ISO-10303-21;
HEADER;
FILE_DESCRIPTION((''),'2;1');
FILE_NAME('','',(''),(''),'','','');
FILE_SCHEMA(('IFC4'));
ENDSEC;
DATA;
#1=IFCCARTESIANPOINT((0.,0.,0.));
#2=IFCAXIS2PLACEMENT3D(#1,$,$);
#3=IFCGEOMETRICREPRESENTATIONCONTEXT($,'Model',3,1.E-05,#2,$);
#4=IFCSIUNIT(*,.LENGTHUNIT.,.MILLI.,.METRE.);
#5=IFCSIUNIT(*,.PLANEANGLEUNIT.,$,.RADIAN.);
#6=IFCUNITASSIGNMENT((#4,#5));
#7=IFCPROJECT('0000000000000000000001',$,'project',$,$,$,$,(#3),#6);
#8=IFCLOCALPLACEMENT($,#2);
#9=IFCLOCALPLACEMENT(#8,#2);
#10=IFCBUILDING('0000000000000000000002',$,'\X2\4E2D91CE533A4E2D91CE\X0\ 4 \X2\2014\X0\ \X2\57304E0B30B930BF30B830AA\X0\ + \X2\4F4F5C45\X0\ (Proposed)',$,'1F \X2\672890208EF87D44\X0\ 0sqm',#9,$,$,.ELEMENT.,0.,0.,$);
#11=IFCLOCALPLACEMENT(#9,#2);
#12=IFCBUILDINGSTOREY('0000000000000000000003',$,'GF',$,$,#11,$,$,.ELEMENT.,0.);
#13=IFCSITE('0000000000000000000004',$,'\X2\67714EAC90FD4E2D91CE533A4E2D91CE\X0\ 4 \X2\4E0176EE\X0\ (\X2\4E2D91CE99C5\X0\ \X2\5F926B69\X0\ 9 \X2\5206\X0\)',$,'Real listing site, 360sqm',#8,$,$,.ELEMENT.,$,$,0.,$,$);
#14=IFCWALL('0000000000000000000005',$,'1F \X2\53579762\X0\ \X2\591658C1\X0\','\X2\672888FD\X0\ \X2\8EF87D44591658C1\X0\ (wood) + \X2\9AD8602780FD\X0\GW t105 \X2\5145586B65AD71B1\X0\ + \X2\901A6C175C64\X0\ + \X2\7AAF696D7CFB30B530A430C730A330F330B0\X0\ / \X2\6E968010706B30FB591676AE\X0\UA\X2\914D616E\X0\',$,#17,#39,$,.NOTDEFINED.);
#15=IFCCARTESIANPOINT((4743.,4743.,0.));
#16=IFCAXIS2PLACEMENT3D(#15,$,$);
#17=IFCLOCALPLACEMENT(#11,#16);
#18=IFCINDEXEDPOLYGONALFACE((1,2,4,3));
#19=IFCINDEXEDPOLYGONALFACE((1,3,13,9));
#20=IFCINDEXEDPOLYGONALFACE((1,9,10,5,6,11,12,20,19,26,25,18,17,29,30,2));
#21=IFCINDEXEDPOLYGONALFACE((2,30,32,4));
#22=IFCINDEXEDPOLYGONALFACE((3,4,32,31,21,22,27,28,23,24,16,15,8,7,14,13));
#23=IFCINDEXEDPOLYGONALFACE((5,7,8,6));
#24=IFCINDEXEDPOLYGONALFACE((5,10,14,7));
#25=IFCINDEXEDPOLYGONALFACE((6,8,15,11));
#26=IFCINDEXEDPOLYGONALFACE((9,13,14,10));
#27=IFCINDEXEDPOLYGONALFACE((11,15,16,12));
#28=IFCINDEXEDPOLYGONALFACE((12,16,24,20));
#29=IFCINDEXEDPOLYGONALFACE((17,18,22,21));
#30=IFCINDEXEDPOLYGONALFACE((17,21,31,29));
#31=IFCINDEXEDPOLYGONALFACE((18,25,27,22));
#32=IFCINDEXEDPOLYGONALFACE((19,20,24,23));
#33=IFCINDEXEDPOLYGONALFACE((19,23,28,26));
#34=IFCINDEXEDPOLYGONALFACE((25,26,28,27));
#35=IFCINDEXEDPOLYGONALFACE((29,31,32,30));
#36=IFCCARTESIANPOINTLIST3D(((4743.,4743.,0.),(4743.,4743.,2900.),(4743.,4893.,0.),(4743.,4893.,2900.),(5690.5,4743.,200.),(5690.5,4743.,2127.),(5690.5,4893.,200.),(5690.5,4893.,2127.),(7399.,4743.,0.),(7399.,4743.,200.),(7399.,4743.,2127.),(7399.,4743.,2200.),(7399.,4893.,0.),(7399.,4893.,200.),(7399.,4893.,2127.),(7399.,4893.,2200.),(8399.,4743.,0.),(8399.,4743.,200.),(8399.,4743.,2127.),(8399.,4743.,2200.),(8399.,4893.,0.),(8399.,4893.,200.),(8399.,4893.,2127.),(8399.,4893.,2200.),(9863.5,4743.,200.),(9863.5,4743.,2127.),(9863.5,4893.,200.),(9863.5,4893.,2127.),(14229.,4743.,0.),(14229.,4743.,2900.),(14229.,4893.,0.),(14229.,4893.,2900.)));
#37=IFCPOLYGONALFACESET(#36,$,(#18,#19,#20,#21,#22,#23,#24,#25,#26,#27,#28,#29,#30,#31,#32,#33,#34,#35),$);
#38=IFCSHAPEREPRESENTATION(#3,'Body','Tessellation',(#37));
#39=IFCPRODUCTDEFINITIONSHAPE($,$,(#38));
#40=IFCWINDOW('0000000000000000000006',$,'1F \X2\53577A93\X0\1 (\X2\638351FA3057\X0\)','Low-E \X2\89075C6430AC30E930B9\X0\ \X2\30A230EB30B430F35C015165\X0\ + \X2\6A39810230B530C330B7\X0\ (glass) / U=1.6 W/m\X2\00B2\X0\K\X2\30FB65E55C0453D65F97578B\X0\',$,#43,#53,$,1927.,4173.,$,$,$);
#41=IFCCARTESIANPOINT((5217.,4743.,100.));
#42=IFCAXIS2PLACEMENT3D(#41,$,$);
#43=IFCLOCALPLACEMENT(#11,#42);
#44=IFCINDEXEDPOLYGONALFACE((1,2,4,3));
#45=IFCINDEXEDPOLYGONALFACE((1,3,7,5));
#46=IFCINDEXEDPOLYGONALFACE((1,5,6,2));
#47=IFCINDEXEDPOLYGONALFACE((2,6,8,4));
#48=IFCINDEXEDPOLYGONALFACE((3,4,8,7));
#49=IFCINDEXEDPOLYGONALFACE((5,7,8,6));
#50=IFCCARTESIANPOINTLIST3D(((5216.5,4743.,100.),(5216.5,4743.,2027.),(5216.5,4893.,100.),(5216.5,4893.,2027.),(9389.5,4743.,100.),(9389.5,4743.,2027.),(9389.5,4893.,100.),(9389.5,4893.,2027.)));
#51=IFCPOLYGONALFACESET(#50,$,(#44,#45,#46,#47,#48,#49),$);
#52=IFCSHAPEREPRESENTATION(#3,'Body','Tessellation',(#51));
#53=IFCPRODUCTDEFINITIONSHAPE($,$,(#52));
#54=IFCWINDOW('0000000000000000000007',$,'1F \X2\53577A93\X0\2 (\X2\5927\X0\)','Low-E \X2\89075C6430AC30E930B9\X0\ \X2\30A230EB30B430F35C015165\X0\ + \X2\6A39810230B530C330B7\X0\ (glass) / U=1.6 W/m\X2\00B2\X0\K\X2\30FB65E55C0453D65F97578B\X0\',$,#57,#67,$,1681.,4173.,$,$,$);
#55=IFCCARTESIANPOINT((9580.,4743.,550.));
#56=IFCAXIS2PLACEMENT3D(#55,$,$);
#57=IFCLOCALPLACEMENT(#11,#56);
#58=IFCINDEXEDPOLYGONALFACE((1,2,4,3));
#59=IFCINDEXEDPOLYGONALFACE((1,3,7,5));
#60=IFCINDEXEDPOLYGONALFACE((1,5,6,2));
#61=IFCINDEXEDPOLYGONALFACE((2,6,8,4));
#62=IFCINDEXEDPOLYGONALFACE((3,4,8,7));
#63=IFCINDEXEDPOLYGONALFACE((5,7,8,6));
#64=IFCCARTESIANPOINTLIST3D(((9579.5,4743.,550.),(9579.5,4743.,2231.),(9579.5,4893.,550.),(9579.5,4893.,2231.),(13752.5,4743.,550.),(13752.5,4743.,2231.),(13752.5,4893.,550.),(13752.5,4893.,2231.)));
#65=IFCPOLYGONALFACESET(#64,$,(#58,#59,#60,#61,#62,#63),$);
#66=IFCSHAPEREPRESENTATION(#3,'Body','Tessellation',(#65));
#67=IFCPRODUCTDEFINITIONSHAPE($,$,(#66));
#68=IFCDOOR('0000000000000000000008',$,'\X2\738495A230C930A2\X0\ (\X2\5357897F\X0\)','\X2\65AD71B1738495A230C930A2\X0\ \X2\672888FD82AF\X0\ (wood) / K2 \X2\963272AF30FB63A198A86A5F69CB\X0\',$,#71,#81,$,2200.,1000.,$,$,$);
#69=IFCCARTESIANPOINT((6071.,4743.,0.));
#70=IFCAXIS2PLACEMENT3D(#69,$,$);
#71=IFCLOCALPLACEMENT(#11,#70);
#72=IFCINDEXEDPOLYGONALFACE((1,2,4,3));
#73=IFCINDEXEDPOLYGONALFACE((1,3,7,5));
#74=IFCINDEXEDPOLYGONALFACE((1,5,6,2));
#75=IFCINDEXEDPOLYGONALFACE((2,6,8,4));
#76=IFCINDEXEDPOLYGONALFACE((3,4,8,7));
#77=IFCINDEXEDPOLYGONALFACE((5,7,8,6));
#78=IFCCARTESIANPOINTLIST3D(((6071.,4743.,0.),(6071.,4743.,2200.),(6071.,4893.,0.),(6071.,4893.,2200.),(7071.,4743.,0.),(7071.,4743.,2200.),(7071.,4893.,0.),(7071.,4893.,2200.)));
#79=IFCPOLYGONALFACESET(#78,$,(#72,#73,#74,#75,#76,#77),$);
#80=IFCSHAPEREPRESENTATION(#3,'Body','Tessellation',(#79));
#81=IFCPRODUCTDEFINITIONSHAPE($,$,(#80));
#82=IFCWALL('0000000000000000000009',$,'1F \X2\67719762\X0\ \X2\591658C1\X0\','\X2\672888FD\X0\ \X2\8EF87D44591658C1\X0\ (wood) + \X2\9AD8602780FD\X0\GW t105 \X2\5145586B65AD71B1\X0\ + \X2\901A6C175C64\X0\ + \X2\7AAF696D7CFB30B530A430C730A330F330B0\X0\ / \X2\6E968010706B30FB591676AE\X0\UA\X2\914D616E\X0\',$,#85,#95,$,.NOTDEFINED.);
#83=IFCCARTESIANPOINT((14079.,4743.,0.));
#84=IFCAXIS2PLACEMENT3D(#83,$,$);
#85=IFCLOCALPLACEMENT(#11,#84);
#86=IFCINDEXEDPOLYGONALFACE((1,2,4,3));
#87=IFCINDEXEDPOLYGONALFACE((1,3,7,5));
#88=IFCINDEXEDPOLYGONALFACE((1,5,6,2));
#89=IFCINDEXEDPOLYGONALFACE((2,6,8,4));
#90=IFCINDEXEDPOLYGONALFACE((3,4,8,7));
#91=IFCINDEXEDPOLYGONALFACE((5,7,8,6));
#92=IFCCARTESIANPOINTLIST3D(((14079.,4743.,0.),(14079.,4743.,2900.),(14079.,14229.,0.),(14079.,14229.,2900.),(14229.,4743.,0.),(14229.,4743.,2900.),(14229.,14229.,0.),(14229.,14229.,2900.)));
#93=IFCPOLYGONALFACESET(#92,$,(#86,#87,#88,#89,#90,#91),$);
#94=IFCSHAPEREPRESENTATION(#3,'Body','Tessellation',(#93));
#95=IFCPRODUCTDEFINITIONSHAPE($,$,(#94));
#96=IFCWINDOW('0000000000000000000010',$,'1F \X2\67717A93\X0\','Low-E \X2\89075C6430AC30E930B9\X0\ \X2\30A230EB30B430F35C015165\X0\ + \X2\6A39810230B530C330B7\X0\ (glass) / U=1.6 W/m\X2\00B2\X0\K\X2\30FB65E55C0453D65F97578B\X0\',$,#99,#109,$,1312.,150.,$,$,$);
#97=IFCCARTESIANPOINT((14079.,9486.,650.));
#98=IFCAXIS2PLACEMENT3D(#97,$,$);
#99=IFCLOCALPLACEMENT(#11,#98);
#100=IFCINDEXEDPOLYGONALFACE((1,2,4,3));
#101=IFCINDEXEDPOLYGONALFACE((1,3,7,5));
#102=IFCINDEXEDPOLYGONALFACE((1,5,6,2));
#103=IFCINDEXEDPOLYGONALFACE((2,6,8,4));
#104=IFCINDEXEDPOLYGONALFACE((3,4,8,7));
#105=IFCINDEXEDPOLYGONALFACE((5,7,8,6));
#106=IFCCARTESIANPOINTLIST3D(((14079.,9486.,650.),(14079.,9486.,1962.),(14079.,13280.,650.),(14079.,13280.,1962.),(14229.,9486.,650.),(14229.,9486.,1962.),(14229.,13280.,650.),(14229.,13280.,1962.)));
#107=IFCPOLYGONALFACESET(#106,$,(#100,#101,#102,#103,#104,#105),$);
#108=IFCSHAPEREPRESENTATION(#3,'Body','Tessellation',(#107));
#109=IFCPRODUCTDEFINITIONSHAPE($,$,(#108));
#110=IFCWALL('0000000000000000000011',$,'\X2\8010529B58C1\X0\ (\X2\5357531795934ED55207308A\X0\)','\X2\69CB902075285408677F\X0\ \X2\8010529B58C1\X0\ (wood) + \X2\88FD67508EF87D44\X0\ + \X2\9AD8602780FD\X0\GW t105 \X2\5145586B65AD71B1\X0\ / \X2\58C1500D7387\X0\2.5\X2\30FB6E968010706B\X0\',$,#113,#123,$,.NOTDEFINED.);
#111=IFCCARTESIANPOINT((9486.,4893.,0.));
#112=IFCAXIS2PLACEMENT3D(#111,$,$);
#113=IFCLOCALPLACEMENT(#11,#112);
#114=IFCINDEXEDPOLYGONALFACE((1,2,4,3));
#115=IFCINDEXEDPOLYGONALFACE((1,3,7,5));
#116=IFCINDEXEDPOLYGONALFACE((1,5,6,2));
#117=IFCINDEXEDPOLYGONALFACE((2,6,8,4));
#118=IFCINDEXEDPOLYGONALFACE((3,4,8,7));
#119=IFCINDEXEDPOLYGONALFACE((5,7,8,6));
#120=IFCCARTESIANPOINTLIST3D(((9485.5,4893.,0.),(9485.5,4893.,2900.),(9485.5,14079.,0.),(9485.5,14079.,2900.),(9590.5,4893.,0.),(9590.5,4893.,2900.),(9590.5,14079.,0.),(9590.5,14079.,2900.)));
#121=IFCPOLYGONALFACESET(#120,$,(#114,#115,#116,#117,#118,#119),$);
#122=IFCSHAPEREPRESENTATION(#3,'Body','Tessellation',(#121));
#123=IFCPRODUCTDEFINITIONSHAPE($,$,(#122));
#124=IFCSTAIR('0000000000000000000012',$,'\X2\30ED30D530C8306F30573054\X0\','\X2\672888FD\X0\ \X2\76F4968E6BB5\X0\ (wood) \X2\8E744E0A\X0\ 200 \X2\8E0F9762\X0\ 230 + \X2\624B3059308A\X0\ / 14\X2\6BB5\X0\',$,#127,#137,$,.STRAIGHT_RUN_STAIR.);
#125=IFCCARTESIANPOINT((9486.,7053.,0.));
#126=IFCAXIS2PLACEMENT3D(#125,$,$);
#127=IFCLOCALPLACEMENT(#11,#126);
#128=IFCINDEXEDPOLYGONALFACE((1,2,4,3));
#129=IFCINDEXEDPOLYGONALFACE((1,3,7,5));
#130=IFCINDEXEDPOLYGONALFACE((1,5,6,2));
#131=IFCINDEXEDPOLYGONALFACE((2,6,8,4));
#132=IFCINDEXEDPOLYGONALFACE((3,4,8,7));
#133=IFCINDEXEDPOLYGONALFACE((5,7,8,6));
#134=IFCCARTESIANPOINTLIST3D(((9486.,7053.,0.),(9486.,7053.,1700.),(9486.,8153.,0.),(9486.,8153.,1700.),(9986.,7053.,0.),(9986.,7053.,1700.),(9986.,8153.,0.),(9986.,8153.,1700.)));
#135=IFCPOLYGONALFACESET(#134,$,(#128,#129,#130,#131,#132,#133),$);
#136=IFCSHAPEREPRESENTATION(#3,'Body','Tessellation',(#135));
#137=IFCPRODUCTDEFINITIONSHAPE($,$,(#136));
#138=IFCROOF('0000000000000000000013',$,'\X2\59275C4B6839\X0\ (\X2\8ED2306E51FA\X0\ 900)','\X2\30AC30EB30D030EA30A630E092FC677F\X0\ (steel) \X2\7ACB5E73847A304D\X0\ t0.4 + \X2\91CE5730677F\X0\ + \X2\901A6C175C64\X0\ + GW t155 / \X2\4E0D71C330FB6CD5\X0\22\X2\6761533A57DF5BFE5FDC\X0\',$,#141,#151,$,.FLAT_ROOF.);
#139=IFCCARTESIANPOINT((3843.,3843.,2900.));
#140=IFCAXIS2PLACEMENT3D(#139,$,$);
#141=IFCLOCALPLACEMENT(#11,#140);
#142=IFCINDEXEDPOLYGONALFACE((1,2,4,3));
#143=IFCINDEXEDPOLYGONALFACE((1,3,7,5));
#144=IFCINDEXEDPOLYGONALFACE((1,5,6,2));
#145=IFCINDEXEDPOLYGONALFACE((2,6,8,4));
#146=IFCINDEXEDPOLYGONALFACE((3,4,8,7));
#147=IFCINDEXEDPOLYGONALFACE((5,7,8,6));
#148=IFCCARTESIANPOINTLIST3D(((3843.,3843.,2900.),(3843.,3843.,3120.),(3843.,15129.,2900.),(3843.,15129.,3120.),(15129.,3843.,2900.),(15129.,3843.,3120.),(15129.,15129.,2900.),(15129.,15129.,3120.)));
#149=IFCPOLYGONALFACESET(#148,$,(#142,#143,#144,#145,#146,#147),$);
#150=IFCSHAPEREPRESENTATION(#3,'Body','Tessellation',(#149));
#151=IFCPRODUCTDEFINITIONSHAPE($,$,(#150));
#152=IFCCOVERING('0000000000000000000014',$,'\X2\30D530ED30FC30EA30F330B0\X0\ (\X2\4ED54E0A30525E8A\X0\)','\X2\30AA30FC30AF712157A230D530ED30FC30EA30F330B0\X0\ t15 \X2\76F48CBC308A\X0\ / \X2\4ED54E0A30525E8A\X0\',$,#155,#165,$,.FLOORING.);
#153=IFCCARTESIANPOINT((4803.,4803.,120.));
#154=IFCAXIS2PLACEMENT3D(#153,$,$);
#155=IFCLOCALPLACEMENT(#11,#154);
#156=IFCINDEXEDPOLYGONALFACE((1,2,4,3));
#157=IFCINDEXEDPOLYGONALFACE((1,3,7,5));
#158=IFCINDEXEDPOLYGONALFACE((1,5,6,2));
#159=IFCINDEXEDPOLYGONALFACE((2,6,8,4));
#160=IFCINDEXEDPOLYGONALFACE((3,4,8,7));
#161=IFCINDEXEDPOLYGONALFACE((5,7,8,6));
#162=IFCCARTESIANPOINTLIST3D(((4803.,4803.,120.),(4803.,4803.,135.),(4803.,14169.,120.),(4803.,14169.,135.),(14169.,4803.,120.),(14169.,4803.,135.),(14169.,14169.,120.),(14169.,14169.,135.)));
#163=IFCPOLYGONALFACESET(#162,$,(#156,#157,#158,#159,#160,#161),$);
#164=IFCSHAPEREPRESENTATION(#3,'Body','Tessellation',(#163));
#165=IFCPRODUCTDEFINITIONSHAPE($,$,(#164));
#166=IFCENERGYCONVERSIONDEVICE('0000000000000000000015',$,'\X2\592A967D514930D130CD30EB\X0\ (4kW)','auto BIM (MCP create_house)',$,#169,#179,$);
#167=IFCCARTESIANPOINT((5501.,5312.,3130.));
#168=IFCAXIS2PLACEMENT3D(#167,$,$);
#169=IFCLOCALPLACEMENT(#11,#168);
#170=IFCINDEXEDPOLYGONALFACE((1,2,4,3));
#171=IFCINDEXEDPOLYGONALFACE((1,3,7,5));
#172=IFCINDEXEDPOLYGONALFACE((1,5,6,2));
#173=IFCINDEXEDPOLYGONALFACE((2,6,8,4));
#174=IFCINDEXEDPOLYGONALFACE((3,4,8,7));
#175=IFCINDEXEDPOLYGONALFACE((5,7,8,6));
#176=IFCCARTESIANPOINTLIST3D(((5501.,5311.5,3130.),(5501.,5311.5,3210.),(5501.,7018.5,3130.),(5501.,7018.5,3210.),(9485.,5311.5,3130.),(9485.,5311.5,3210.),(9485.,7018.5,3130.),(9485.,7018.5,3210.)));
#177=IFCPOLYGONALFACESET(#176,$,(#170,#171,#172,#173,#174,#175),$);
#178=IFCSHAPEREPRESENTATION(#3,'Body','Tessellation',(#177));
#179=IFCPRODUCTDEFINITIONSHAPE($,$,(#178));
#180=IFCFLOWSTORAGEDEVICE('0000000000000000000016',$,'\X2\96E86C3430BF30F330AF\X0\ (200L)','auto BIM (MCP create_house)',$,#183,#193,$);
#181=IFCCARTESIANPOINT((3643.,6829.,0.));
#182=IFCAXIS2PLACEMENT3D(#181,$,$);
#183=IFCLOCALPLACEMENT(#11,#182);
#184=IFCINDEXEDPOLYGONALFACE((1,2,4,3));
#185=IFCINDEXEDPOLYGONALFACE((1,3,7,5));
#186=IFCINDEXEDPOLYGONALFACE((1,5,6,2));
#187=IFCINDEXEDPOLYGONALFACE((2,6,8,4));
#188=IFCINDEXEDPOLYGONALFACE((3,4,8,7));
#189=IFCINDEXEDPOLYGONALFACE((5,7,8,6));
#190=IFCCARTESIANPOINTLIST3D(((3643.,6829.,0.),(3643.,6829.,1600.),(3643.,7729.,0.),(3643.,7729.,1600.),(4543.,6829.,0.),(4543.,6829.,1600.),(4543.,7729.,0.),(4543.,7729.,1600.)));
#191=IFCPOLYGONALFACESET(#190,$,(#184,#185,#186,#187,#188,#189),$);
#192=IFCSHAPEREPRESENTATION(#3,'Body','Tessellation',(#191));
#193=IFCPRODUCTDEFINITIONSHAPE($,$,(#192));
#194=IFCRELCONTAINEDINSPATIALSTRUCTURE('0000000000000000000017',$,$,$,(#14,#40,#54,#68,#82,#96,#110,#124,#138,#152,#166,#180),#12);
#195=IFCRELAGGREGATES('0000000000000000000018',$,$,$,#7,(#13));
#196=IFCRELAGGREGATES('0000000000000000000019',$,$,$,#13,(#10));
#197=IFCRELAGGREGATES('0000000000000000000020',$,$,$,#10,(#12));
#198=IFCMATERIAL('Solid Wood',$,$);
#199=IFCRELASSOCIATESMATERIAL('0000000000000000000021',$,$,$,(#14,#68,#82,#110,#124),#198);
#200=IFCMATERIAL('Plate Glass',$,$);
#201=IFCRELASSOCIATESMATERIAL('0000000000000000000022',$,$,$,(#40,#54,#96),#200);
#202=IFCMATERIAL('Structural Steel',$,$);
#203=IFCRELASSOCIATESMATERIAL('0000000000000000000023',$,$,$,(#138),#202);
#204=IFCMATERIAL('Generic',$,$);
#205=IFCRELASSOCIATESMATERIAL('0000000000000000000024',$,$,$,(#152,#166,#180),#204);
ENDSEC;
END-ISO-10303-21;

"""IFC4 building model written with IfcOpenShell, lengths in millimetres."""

from ifc_helpers import new_model, si_unit, frame, frame_2d, origin, place, context, project, spatial, rectangle, extrude, material, element, fill, save


model = new_model("IFC4")

# Units and contexts
model_context = context("Model", 3, precision=1e-05, world=origin())
ifc_project = project(units=[si_unit("LENGTHUNIT", "METRE", prefix="MILLI"), si_unit("PLANEANGLEUNIT", "RADIAN")], contexts=[model_context])

# Site, building, storey
site_placement = place(None, origin())
site = spatial("IfcSite", under=ifc_project, at=site_placement, Name="東京都中野区中野 4 丁目 (中野駅 徒歩 9 分)", ObjectType="Real listing site, 360sqm", CompositionType="ELEMENT", RefElevation=0.0)
building_placement = place(site_placement, origin())
building = spatial("IfcBuilding", under=site, at=building_placement, Name="中野区中野 4 — 地下スタジオ + 住居 (Proposed)", ObjectType="1F 木造軸組 0sqm", CompositionType="ELEMENT", ElevationOfRefHeight=0.0, ElevationOfTerrain=0.0)
storey_placement = place(building_placement, origin())
storey = spatial("IfcBuildingStorey", under=building, at=storey_placement, Name="GF", CompositionType="ELEMENT", Elevation=0.0)

# Shared definitions
ifc_material_1 = material(Name="Solid Wood")

# Wall, openings, windows, door
wall_1_placement = place(storey_placement, frame((4743.0, 4743.0, 0.0)))
wall_1 = element("IfcWall", 1, at=wall_1_placement, inside=storey, material=ifc_material_1, Name="1F 南面 外壁", Description="木製 軸組外壁 (wood) + 高性能GW t105 充填断熱 + 通気層 + 窯業系サイディング / 準耐火・外皮UA配慮", PredefinedType="NOTDEFINED", context=model_context, shape_type="SweptSolid", body=[
    extrude(rectangle(XDim=9486.0, YDim=150.0, at=frame_2d((4743.0, 75.0))), frame((4743.0, 4743.0, 0.0)), (0.0, 0.0, 1.0), 2900.0),
])
opening_1_placement = place(storey_placement, frame((5217.0, 4743.0, 100.0)))
opening_1 = element("IfcOpeningElement", 2, at=opening_1_placement, cuts=wall_1, PredefinedType="NOTDEFINED", context=model_context, shape_type="SweptSolid", body=[
    extrude(rectangle(XDim=4173.0, YDim=150.0, at=frame_2d((2086.0, 75.0))), frame((5217.0, 4743.0, 100.0)), (0.0, 0.0, 1.0), 1927.0),
])
opening_2_placement = place(storey_placement, frame((9580.0, 4743.0, 550.0)))
opening_2 = element("IfcOpeningElement", 3, at=opening_2_placement, cuts=wall_1, PredefinedType="NOTDEFINED", context=model_context, shape_type="SweptSolid", body=[
    extrude(rectangle(XDim=4173.0, YDim=150.0, at=frame_2d((2086.0, 75.0))), frame((9580.0, 4743.0, 550.0)), (0.0, 0.0, 1.0), 1681.0),
])
opening_3_placement = place(storey_placement, frame((6071.0, 4743.0, 0.0)))
opening_3 = element("IfcOpeningElement", 4, at=opening_3_placement, cuts=wall_1, PredefinedType="NOTDEFINED", context=model_context, shape_type="SweptSolid", body=[
    extrude(rectangle(XDim=1000.0, YDim=150.0, at=frame_2d((500.0, 75.0))), frame((6071.0, 4743.0, 0.0)), (0.0, 0.0, 1.0), 2200.0),
])
ifc_material_2 = material(Name="Plate Glass")
window_1_placement = place(storey_placement, frame((5217.0, 4743.0, 100.0)))
window_1 = element("IfcWindow", 5, at=window_1_placement, inside=storey, material=ifc_material_2, Name="1F 南窓1 (掃出し)", Description="Low-E 複層ガラス アルゴン封入 + 樹脂サッシ (glass) / U=1.6 W/m²K・日射取得型", OverallHeight=1927.0, OverallWidth=4173.0, context=model_context, shape_type="SweptSolid", body=[
    extrude(rectangle(XDim=4173.0, YDim=150.0, at=frame_2d((2086.0, 75.0))), frame((5217.0, 4743.0, 100.0)), (0.0, 0.0, 1.0), 1927.0),
])
fill(opening_1, window_1)
window_2_placement = place(storey_placement, frame((9580.0, 4743.0, 550.0)))
window_2 = element("IfcWindow", 6, at=window_2_placement, inside=storey, material=ifc_material_2, Name="1F 南窓2 (大)", Description="Low-E 複層ガラス アルゴン封入 + 樹脂サッシ (glass) / U=1.6 W/m²K・日射取得型", OverallHeight=1681.0, OverallWidth=4173.0, context=model_context, shape_type="SweptSolid", body=[
    extrude(rectangle(XDim=4173.0, YDim=150.0, at=frame_2d((2086.0, 75.0))), frame((9580.0, 4743.0, 550.0)), (0.0, 0.0, 1.0), 1681.0),
])
fill(opening_2, window_2)
door_placement = place(storey_placement, frame((6071.0, 4743.0, 0.0)))
door = element("IfcDoor", 7, at=door_placement, inside=storey, material=ifc_material_1, Name="玄関ドア (南西)", Description="断熱玄関ドア 木製芯 (wood) / K2 防犯・採風機構", OverallHeight=2200.0, OverallWidth=1000.0, context=model_context, shape_type="SweptSolid", body=[
    extrude(rectangle(XDim=1000.0, YDim=150.0, at=frame_2d((500.0, 75.0))), frame((6071.0, 4743.0, 0.0)), (0.0, 0.0, 1.0), 2200.0),
])
fill(opening_3, door)

# Wall, opening, window
wall_2_placement = place(storey_placement, frame((14079.0, 4743.0, 0.0)))
wall_2 = element("IfcWall", 8, at=wall_2_placement, inside=storey, material=ifc_material_1, Name="1F 東面 外壁", Description="木製 軸組外壁 (wood) + 高性能GW t105 充填断熱 + 通気層 + 窯業系サイディング / 準耐火・外皮UA配慮", PredefinedType="NOTDEFINED", context=model_context, shape_type="SweptSolid", body=[
    extrude(rectangle(XDim=150.0, YDim=9486.0, at=frame_2d((75.0, 4743.0))), frame((14079.0, 4743.0, 0.0)), (0.0, 0.0, 1.0), 2900.0),
])
opening_4_placement = place(storey_placement, frame((14079.0, 9486.0, 650.0)))
opening_4 = element("IfcOpeningElement", 9, at=opening_4_placement, cuts=wall_2, PredefinedType="NOTDEFINED", context=model_context, shape_type="SweptSolid", body=[
    extrude(rectangle(XDim=150.0, YDim=3794.0, at=frame_2d((75.0, 1897.0))), frame((14079.0, 9486.0, 650.0)), (0.0, 0.0, 1.0), 1312.0),
])
window_3_placement = place(storey_placement, frame((14079.0, 9486.0, 650.0)))
window_3 = element("IfcWindow", 10, at=window_3_placement, inside=storey, material=ifc_material_2, Name="1F 東窓", Description="Low-E 複層ガラス アルゴン封入 + 樹脂サッシ (glass) / U=1.6 W/m²K・日射取得型", OverallHeight=1312.0, OverallWidth=150.0, context=model_context, shape_type="SweptSolid", body=[
    extrude(rectangle(XDim=150.0, YDim=3794.0, at=frame_2d((75.0, 1897.0))), frame((14079.0, 9486.0, 650.0)), (0.0, 0.0, 1.0), 1312.0),
])
fill(opening_4, window_3)

# Wall
wall_3_placement = place(storey_placement, frame((9486.0, 4893.0, 0.0)))
element("IfcWall", 11, at=wall_3_placement, inside=storey, material=ifc_material_1, Name="耐力壁 (南北間仕切り)", Description="構造用合板 耐力壁 (wood) + 製材軸組 + 高性能GW t105 充填断熱 / 壁倍率2.5・準耐火", PredefinedType="NOTDEFINED", context=model_context, shape_type="SweptSolid", body=[
    extrude(rectangle(XDim=105.0, YDim=9186.0, at=frame_2d((52.0, 4593.0))), frame((9486.0, 4893.0, 0.0)), (0.0, 0.0, 1.0), 2900.0),
])

# Stair
stair_placement = place(storey_placement, frame((9486.0, 7053.0, 0.0)))
element("IfcStair", 12, at=stair_placement, inside=storey, material=ifc_material_1, Name="ロフトはしご", Description="木製 直階段 (wood) 蹴上 200 踏面 230 + 手すり / 14段", PredefinedType="STRAIGHT_RUN_STAIR", context=model_context, shape_type="SweptSolid", body=[
    extrude(rectangle(XDim=500.0, YDim=1100.0, at=frame_2d((250.0, 550.0))), frame((9486.0, 7053.0, 0.0)), (0.0, 0.0, 1.0), 1700.0),
])

# Roof
ifc_material_3 = material(Name="Structural Steel")
roof_placement = place(storey_placement, frame((3843.0, 3843.0, 2900.0)))
element("IfcRoof", 13, at=roof_placement, inside=storey, material=ifc_material_3, Name="大屋根 (軒の出 900)", Description="ガルバリウム鋼板 (steel) 立平葺き t0.4 + 野地板 + 通気層 + GW t155 / 不燃・法22条区域対応", PredefinedType="FLAT_ROOF", context=model_context, shape_type="SweptSolid", body=[
    extrude(rectangle(XDim=11286.0, YDim=11286.0, at=frame_2d((5643.0, 5643.0))), frame((3843.0, 3843.0, 2900.0)), (0.0, 0.0, 1.0), 220.0),
])

# Covering
ifc_material_4 = material(Name="Generic")
covering_placement = place(storey_placement, frame((4803.0, 4803.0, 120.0)))
element("IfcCovering", 14, at=covering_placement, inside=storey, material=ifc_material_4, Name="フローリング (仕上げ床)", Description="オーク無垢フローリング t15 直貼り / 仕上げ床", PredefinedType="FLOORING", context=model_context, shape_type="SweptSolid", body=[
    extrude(rectangle(XDim=9366.0, YDim=9366.0, at=frame_2d((4683.0, 4683.0))), frame((4803.0, 4803.0, 120.0)), (0.0, 0.0, 1.0), 15.0),
])

# Energy conversion device
energy_conversion_device_placement = place(storey_placement, frame((5501.0, 5312.0, 3130.0)))
element("IfcEnergyConversionDevice", 15, at=energy_conversion_device_placement, inside=storey, material=ifc_material_4, Name="太陽光パネル (4kW)", Description="auto BIM (MCP create_house)", context=model_context, shape_type="SweptSolid", body=[
    extrude(rectangle(XDim=3984.0, YDim=1707.0, at=frame_2d((1992.0, 853.0))), frame((5501.0, 5312.0, 3130.0)), (0.0, 0.0, 1.0), 80.0),
])

# Flow storage device
flow_storage_device_placement = place(storey_placement, frame((3643.0, 6829.0, 0.0)))
element("IfcFlowStorageDevice", 16, at=flow_storage_device_placement, inside=storey, material=ifc_material_4, Name="雨水タンク (200L)", Description="auto BIM (MCP create_house)", context=model_context, shape_type="SweptSolid", body=[
    extrude(rectangle(XDim=900.0, YDim=900.0, at=frame_2d((450.0, 450.0))), frame((3643.0, 6829.0, 0.0)), (0.0, 0.0, 1.0), 1600.0),
])

save(model, "model.ifc")
